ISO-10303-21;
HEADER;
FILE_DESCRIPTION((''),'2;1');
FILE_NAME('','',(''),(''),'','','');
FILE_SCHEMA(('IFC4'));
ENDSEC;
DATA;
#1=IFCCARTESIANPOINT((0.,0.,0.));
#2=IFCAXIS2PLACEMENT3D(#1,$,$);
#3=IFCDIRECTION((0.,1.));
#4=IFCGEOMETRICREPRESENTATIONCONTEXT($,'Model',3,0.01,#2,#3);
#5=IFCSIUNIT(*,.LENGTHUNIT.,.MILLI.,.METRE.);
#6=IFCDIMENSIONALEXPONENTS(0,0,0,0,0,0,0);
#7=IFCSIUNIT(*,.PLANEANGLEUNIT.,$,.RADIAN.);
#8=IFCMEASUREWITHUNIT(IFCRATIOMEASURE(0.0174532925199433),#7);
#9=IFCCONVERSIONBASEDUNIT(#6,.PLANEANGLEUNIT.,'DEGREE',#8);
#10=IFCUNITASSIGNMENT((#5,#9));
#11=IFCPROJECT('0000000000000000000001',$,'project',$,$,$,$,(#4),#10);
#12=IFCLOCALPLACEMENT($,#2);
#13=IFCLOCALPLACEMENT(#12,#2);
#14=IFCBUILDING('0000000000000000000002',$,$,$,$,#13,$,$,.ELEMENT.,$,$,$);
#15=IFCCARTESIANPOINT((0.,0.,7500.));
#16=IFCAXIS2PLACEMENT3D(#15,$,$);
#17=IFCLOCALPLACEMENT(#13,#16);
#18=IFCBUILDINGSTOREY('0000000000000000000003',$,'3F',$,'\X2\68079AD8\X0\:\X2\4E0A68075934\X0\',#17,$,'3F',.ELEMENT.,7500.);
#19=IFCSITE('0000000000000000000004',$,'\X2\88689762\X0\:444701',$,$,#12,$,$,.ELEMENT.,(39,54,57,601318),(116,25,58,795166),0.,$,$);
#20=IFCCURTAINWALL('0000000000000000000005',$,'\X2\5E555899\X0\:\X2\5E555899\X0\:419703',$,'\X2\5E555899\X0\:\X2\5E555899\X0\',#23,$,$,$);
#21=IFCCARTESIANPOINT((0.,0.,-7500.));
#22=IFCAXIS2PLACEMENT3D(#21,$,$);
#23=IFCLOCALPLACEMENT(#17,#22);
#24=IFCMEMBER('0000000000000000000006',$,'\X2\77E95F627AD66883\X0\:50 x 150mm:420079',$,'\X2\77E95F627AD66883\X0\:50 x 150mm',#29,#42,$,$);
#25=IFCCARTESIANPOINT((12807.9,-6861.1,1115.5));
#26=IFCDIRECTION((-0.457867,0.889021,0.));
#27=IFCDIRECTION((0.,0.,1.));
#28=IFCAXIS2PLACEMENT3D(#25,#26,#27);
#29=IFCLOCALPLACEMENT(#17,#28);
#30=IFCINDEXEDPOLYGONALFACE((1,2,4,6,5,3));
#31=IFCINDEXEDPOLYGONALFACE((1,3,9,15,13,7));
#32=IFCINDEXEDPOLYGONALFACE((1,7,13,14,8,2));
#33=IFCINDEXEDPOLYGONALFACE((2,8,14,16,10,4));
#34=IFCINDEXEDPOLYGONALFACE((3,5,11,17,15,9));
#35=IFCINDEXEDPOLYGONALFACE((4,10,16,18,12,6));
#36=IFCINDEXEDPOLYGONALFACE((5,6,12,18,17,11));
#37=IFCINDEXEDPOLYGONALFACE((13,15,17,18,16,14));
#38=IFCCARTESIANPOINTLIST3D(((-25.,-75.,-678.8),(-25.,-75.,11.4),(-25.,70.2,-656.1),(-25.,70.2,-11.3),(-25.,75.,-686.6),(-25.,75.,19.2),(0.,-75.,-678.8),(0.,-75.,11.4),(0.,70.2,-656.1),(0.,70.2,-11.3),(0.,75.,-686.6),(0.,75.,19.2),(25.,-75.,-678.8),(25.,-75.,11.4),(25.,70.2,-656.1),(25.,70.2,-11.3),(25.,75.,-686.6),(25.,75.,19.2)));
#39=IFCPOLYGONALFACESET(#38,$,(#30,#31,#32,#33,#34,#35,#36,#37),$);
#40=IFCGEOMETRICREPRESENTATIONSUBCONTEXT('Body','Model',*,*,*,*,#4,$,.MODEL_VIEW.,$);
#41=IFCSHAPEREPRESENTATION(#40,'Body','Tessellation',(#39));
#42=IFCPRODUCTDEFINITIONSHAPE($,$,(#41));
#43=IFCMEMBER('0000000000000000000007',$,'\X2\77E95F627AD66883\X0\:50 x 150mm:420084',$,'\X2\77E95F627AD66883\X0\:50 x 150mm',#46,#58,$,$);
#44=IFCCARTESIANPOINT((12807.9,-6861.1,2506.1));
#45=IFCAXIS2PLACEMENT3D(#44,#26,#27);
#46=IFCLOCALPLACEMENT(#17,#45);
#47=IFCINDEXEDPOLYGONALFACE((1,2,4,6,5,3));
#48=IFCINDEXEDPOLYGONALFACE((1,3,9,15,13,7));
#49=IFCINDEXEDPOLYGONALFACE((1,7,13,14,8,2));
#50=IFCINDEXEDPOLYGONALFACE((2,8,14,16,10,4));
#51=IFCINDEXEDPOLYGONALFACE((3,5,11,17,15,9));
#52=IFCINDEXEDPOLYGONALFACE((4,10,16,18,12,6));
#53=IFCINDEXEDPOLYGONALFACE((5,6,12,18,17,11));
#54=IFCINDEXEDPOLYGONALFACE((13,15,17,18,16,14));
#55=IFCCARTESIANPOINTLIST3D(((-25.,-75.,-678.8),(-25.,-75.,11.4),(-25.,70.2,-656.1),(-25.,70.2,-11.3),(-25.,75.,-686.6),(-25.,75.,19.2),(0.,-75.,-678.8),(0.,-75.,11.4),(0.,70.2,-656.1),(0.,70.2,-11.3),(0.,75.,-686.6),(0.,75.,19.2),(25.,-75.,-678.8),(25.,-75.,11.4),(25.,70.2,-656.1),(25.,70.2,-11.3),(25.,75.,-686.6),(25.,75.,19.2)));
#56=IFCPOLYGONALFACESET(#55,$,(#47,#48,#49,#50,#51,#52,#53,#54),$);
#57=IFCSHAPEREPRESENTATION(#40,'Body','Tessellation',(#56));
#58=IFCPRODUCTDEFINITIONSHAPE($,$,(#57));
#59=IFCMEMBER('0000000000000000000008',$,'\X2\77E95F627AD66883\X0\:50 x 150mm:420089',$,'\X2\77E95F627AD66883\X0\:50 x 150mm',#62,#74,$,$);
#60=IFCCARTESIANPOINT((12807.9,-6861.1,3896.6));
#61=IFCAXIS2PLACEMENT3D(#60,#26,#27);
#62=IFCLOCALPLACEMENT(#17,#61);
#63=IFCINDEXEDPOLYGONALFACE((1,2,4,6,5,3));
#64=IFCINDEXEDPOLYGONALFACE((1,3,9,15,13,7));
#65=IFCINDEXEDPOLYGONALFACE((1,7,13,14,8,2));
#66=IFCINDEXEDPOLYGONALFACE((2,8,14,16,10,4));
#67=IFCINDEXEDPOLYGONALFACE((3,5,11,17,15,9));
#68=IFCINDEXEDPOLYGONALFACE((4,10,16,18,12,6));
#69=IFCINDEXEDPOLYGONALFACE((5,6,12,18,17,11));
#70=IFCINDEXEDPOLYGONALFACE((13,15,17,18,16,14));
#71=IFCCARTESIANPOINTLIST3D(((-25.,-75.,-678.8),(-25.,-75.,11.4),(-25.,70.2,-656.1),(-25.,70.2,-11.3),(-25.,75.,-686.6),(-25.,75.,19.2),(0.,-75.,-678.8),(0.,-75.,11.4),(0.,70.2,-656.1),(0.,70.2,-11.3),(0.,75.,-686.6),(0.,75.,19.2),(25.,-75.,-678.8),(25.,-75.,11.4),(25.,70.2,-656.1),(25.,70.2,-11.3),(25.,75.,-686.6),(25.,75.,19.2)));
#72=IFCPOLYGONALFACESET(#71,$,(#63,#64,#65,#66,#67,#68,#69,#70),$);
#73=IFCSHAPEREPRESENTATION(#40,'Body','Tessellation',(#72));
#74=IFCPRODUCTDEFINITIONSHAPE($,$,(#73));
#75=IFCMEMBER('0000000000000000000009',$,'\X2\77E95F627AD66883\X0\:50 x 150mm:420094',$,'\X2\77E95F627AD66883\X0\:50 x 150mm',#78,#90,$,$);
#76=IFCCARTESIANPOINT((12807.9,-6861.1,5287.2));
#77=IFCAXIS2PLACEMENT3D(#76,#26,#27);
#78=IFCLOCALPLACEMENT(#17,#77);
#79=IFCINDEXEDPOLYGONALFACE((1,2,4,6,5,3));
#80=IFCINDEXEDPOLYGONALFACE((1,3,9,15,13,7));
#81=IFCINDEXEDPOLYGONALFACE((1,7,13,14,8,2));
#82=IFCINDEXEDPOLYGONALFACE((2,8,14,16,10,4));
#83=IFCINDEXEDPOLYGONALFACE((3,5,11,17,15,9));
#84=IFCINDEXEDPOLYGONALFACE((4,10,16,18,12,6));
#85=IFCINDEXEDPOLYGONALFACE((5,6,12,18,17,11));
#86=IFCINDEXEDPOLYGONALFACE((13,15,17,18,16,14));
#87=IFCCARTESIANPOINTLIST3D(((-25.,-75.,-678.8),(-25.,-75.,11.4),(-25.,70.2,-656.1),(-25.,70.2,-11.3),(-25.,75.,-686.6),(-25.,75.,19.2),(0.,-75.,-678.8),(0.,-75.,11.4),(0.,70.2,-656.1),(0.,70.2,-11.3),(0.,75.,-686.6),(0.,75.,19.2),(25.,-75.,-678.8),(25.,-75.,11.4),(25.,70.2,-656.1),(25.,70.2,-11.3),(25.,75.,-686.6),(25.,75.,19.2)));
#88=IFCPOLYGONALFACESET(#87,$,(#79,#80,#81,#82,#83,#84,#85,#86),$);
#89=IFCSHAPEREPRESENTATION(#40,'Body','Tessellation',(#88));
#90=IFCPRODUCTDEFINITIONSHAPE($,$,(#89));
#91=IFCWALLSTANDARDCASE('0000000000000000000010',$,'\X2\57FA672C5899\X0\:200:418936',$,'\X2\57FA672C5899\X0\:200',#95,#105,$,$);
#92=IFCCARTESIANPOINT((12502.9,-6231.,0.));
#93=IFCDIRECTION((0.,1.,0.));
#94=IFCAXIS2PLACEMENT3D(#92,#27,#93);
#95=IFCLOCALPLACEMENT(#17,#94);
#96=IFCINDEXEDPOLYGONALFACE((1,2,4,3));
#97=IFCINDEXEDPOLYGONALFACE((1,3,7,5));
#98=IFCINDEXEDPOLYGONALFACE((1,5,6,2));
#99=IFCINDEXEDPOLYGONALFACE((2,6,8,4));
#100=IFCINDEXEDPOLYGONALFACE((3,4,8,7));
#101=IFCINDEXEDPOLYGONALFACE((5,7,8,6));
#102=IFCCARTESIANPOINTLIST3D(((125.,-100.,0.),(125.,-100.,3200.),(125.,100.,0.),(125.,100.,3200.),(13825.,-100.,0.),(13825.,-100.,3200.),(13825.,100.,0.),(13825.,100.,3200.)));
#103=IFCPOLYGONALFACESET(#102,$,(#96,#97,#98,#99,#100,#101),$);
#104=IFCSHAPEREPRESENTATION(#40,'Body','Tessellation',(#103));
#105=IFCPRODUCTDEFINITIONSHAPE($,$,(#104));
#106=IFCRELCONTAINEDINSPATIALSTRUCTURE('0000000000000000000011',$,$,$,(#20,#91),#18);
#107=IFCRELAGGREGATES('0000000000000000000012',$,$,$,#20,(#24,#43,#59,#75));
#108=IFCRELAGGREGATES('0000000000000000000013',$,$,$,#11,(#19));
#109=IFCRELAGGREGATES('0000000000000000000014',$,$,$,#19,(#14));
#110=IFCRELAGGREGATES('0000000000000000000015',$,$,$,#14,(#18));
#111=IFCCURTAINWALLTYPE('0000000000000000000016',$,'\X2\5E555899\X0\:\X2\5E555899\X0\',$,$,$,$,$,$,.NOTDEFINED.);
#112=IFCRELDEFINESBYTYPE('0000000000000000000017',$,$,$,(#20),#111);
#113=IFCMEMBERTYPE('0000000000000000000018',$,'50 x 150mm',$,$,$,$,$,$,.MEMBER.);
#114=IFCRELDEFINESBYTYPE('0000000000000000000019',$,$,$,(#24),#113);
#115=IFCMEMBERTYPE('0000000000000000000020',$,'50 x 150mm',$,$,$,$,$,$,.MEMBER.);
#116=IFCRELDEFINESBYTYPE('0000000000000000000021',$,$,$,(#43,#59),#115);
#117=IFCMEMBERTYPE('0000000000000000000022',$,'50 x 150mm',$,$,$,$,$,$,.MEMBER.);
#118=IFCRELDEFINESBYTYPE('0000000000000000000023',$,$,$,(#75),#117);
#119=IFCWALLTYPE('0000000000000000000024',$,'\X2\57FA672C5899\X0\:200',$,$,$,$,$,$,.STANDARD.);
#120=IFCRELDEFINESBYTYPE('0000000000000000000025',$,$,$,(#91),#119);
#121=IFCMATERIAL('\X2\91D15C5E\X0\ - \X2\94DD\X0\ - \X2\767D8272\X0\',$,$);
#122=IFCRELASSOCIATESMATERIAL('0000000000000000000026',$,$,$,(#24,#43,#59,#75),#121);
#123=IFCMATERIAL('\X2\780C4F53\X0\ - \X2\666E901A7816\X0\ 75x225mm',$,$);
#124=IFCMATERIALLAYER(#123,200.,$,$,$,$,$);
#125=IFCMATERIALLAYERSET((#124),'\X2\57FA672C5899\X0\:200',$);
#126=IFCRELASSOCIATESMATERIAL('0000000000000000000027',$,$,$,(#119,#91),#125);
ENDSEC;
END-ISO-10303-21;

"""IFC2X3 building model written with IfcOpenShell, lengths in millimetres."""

from ifc_helpers import new_model, entity, si_unit, converted_unit, direction, frame, frame_2d, origin, origin_2d_with_axis, place, context, subcontext, project, spatial, polyline, rectangle, extrude, clip, bounded_halfspace, source, transform, mapped, material, layer, layer_set, layer_usage, type_object, type_shapes, element, aggregate, save


model = new_model("IFC2X3")

# Units and contexts
model_context = context("Model", 3, precision=0.01, world=origin(), true_north=direction((0.0, 1.0)))
body_context = subcontext(model_context, "Body", "Model", "MODEL_VIEW")
ifc_project = project(units=[si_unit("LENGTHUNIT", "METRE", prefix="MILLI"), converted_unit("PLANEANGLEUNIT", "DEGREE", entity("IfcRatioMeasure", 0.0174532925199433), si_unit("PLANEANGLEUNIT", "RADIAN"), dimensions=[0, 0, 0, 0, 0, 0, 0])], contexts=[model_context])

# Site, building, storey
site_placement = place(None, origin())
site = spatial("IfcSite", under=ifc_project, at=site_placement, Name="表面:444701", CompositionType="ELEMENT", RefLatitude=(39, 54, 57, 601318), RefLongitude=(116, 25, 58, 795166), RefElevation=0.0)
building_placement = place(site_placement, origin())
building = spatial("IfcBuilding", under=site, at=building_placement, CompositionType="ELEMENT")
storey_placement = place(building_placement, frame((0.0, 0.0, 7500.0)))
storey = spatial("IfcBuildingStorey", under=building, at=storey_placement, Name="3F", ObjectType="标高:上标头", LongName="3F", CompositionType="ELEMENT", Elevation=7500.0)

# Shared definitions
curtain_wall_type = type_object("IfcCurtainWallType", Name="幕墙:幕墙", PredefinedType="NOTDEFINED")
ifc_material_1 = material(Name="金属 - 铝 - 白色")

# Curtain wall, members
curtain_wall_1_placement = place(storey_placement, frame((0.0, 0.0, -7500.0)))
curtain_wall_1 = element("IfcCurtainWall", 1, at=curtain_wall_1_placement, inside=storey, type_object=curtain_wall_type, Name="幕墙:幕墙:419703", ObjectType="幕墙:幕墙")
member_type_1 = type_object("IfcMemberType", Name="50 x 150mm", PredefinedType="MEMBER")
shared_shape_1 = source(origin(), body_context, "Body", "Clipping", [
    clip(clip(clip(clip(clip(clip(clip(clip(extrude(rectangle(XDim=150.0, YDim=50.0, at=origin_2d_with_axis()), frame((0.0, 0.0, -686.6), z_axis=(0.0, 0.0, 1.0), x_axis=(0.0, -1.0, 0.0)), (0.0, 0.0, 1.0), 705.8), bounded_halfspace(frame((-1415.5, -78.0, -679.3), z_axis=(0.0, 0.154283, -0.988027), x_axis=(1.0, 0.0, 0.0)), False, frame((0.0, 0.0, -686.6), z_axis=(0.0, 0.0, 1.0), x_axis=(0.0, -1.0, 0.0)), polyline([(75.0, 0.0), (75.0, -25.0), (-70.2, -25.0), (-70.2, 0.0), (75.0, 0.0)]))), bounded_halfspace(frame((0.0, -78.0, -679.3), z_axis=(0.0, 0.154283, -0.988027), x_axis=(1.0, 0.0, 0.0)), False, frame((0.0, 0.0, -686.6), z_axis=(0.0, 0.0, 1.0), x_axis=(0.0, -1.0, 0.0)), polyline([(-70.2, 25.0), (75.0, 25.0), (75.0, 0.0), (-70.2, 0.0), (-70.2, 25.0)]))), bounded_halfspace(frame((-1415.5, 70.2, -656.1), z_axis=(0.0, -0.988027, -0.154283), x_axis=(1.0, 0.0, 0.0)), False, frame((0.0, 0.0, -686.6), z_axis=(0.0, 0.0, 1.0), x_axis=(0.0, -1.0, 0.0)), polyline([(-70.2, -25.0), (-75.0, -25.0), (-75.0, 0.0), (-70.2, 0.0), (-70.2, -25.0)]))), bounded_halfspace(frame((0.0, 70.2, -656.1), z_axis=(0.0, -0.988027, -0.154283), x_axis=(1.0, 0.0, 0.0)), False, frame((0.0, 0.0, -686.6), z_axis=(0.0, 0.0, 1.0), x_axis=(0.0, -1.0, 0.0)), polyline([(-75.0, 25.0), (-70.2, 25.0), (-70.2, 0.0), (-75.0, 0.0), (-75.0, 25.0)]))), bounded_halfspace(frame((-1415.5, 78.0, 38.1), z_axis=(0.0, -0.988027, 0.154283), x_axis=(1.0, 0.0, 0.0)), False, frame((0.0, 0.0, -686.6), z_axis=(0.0, 0.0, 1.0), x_axis=(0.0, -1.0, 0.0)), polyline([(-75.0, 0.0), (-75.0, -25.0), (-70.2, -25.0), (-70.2, 0.0), (-75.0, 0.0)]))), bounded_halfspace(frame((0.0, 78.0, 38.1), z_axis=(0.0, -0.988027, 0.154283), x_axis=(1.0, 0.0, 0.0)), False, frame((0.0, 0.0, -686.6), z_axis=(0.0, 0.0, 1.0), x_axis=(0.0, -1.0, 0.0)), polyline([(-75.0, 25.0), (-75.0, 0.0), (-70.2, 0.0), (-70.2, 25.0), (-75.0, 25.0)]))), bounded_halfspace(frame((-1415.5, 70.2, -11.3), z_axis=(0.0, 0.154283, 0.988027), x_axis=(1.0, 0.0, 0.0)), False, frame((0.0, 0.0, -686.6), z_axis=(0.0, 0.0, 1.0), x_axis=(0.0, -1.0, 0.0)), polyline([(-70.2, -25.0), (75.0, -25.0), (75.0, 0.0), (-70.2, 0.0), (-70.2, -25.0)]))), bounded_halfspace(frame((0.0, 70.2, -11.3), z_axis=(0.0, 0.154283, 0.988027), x_axis=(1.0, 0.0, 0.0)), False, frame((0.0, 0.0, -686.6), z_axis=(0.0, 0.0, 1.0), x_axis=(0.0, -1.0, 0.0)), polyline([(75.0, 0.0), (75.0, 25.0), (-70.2, 25.0), (-70.2, 0.0), (75.0, 0.0)]))),
])
type_shapes(member_type_1, [shared_shape_1])
member_1_placement = place(storey_placement, frame((12807.9, -6861.1, 1115.5), z_axis=(-0.457867, 0.889021, 0.0), x_axis=(0.0, 0.0, 1.0)))
member_1 = element("IfcMember", 2, at=member_1_placement, type_object=member_type_1, material=ifc_material_1, Name="矩形竖梃:50 x 150mm:420079", ObjectType="矩形竖梃:50 x 150mm", context=body_context, shape_type="MappedRepresentation", body=[
    mapped(shared_shape_1, transform((0.0, 0.0, 0.0), scale=1.0)),
])
member_type_2 = type_object("IfcMemberType", Name="50 x 150mm", PredefinedType="MEMBER")
shared_shape_2 = source(origin(), body_context, "Body", "Clipping", [
    clip(clip(clip(clip(clip(clip(clip(clip(extrude(rectangle(XDim=150.0, YDim=50.0, at=origin_2d_with_axis()), frame((0.0, 0.0, -686.6), z_axis=(0.0, 0.0, 1.0), x_axis=(0.0, -1.0, 0.0)), (0.0, 0.0, 1.0), 705.8), bounded_halfspace(frame((-1390.5, -78.0, -679.3), z_axis=(0.0, 0.154283, -0.988027), x_axis=(1.0, 0.0, 0.0)), False, frame((0.0, 0.0, -686.6), z_axis=(0.0, 0.0, 1.0), x_axis=(0.0, -1.0, 0.0)), polyline([(75.0, 0.0), (75.0, -25.0), (-70.2, -25.0), (-70.2, 0.0), (75.0, 0.0)]))), bounded_halfspace(frame((0.0, -78.0, -679.3), z_axis=(0.0, 0.154283, -0.988027), x_axis=(1.0, 0.0, 0.0)), False, frame((0.0, 0.0, -686.6), z_axis=(0.0, 0.0, 1.0), x_axis=(0.0, -1.0, 0.0)), polyline([(-70.2, 25.0), (75.0, 25.0), (75.0, 0.0), (-70.2, 0.0), (-70.2, 25.0)]))), bounded_halfspace(frame((-1390.5, 70.2, -656.1), z_axis=(0.0, -0.988027, -0.154283), x_axis=(1.0, 0.0, 0.0)), False, frame((0.0, 0.0, -686.6), z_axis=(0.0, 0.0, 1.0), x_axis=(0.0, -1.0, 0.0)), polyline([(-70.2, -25.0), (-75.0, -25.0), (-75.0, 0.0), (-70.2, 0.0), (-70.2, -25.0)]))), bounded_halfspace(frame((0.0, 70.2, -656.1), z_axis=(0.0, -0.988027, -0.154283), x_axis=(1.0, 0.0, 0.0)), False, frame((0.0, 0.0, -686.6), z_axis=(0.0, 0.0, 1.0), x_axis=(0.0, -1.0, 0.0)), polyline([(-75.0, 25.0), (-70.2, 25.0), (-70.2, 0.0), (-75.0, 0.0), (-75.0, 25.0)]))), bounded_halfspace(frame((-1390.5, 78.0, 38.1), z_axis=(0.0, -0.988027, 0.154283), x_axis=(1.0, 0.0, 0.0)), False, frame((0.0, 0.0, -686.6), z_axis=(0.0, 0.0, 1.0), x_axis=(0.0, -1.0, 0.0)), polyline([(-75.0, 0.0), (-75.0, -25.0), (-70.2, -25.0), (-70.2, 0.0), (-75.0, 0.0)]))), bounded_halfspace(frame((0.0, 78.0, 38.1), z_axis=(0.0, -0.988027, 0.154283), x_axis=(1.0, 0.0, 0.0)), False, frame((0.0, 0.0, -686.6), z_axis=(0.0, 0.0, 1.0), x_axis=(0.0, -1.0, 0.0)), polyline([(-75.0, 25.0), (-75.0, 0.0), (-70.2, 0.0), (-70.2, 25.0), (-75.0, 25.0)]))), bounded_halfspace(frame((-1390.5, 70.2, -11.3), z_axis=(0.0, 0.154283, 0.988027), x_axis=(1.0, 0.0, 0.0)), False, frame((0.0, 0.0, -686.6), z_axis=(0.0, 0.0, 1.0), x_axis=(0.0, -1.0, 0.0)), polyline([(-70.2, -25.0), (75.0, -25.0), (75.0, 0.0), (-70.2, 0.0), (-70.2, -25.0)]))), bounded_halfspace(frame((0.0, 70.2, -11.3), z_axis=(0.0, 0.154283, 0.988027), x_axis=(1.0, 0.0, 0.0)), False, frame((0.0, 0.0, -686.6), z_axis=(0.0, 0.0, 1.0), x_axis=(0.0, -1.0, 0.0)), polyline([(75.0, 0.0), (75.0, 25.0), (-70.2, 25.0), (-70.2, 0.0), (75.0, 0.0)]))),
])
type_shapes(member_type_2, [shared_shape_2])
member_2_placement = place(storey_placement, frame((12807.9, -6861.1, 2506.1), z_axis=(-0.457867, 0.889021, 0.0), x_axis=(0.0, 0.0, 1.0)))
member_2 = element("IfcMember", 3, at=member_2_placement, type_object=member_type_2, material=ifc_material_1, Name="矩形竖梃:50 x 150mm:420084", ObjectType="矩形竖梃:50 x 150mm", context=body_context, shape_type="MappedRepresentation", body=[
    mapped(shared_shape_2, transform((0.0, 0.0, 0.0), scale=1.0)),
])
member_3_placement = place(storey_placement, frame((12807.9, -6861.1, 3896.6), z_axis=(-0.457867, 0.889021, 0.0), x_axis=(0.0, 0.0, 1.0)))
member_3 = element("IfcMember", 4, at=member_3_placement, type_object=member_type_2, material=ifc_material_1, Name="矩形竖梃:50 x 150mm:420089", ObjectType="矩形竖梃:50 x 150mm", context=body_context, shape_type="MappedRepresentation", body=[
    mapped(shared_shape_2, transform((0.0, 0.0, 0.0), scale=1.0)),
])
member_type_3 = type_object("IfcMemberType", Name="50 x 150mm", PredefinedType="MEMBER")
shared_shape_3 = source(origin(), body_context, "Body", "Clipping", [
    clip(clip(clip(clip(clip(clip(clip(clip(extrude(rectangle(XDim=150.0, YDim=50.0, at=origin_2d_with_axis()), frame((0.0, 0.0, -686.6), z_axis=(0.0, 0.0, 1.0), x_axis=(0.0, -1.0, 0.0)), (0.0, 0.0, 1.0), 705.8), bounded_halfspace(frame((-1390.5, -78.0, -679.3), z_axis=(0.0, 0.154283, -0.988027), x_axis=(1.0, 0.0, 0.0)), False, frame((0.0, 0.0, -686.6), z_axis=(0.0, 0.0, 1.0), x_axis=(0.0, -1.0, 0.0)), polyline([(75.0, 0.0), (75.0, -25.0), (-70.2, -25.0), (-70.2, 0.0), (75.0, 0.0)]))), bounded_halfspace(frame((0.0, -78.0, -679.3), z_axis=(0.0, 0.154283, -0.988027), x_axis=(1.0, 0.0, 0.0)), False, frame((0.0, 0.0, -686.6), z_axis=(0.0, 0.0, 1.0), x_axis=(0.0, -1.0, 0.0)), polyline([(-70.2, 25.0), (75.0, 25.0), (75.0, 0.0), (-70.2, 0.0), (-70.2, 25.0)]))), bounded_halfspace(frame((-1390.5, 70.2, -656.1), z_axis=(0.0, -0.988027, -0.154283), x_axis=(1.0, 0.0, 0.0)), False, frame((0.0, 0.0, -686.6), z_axis=(0.0, 0.0, 1.0), x_axis=(0.0, -1.0, 0.0)), polyline([(-70.2, -25.0), (-75.0, -25.0), (-75.0, 0.0), (-70.2, 0.0), (-70.2, -25.0)]))), bounded_halfspace(frame((0.0, 70.2, -656.1), z_axis=(0.0, -0.988027, -0.154283), x_axis=(1.0, 0.0, 0.0)), False, frame((0.0, 0.0, -686.6), z_axis=(0.0, 0.0, 1.0), x_axis=(0.0, -1.0, 0.0)), polyline([(-75.0, 25.0), (-70.2, 25.0), (-70.2, 0.0), (-75.0, 0.0), (-75.0, 25.0)]))), bounded_halfspace(frame((-1390.5, 78.0, 38.1), z_axis=(0.0, -0.988027, 0.154283), x_axis=(1.0, 0.0, 0.0)), False, frame((0.0, 0.0, -686.6), z_axis=(0.0, 0.0, 1.0), x_axis=(0.0, -1.0, 0.0)), polyline([(-75.0, 0.0), (-75.0, -25.0), (-70.2, -25.0), (-70.2, 0.0), (-75.0, 0.0)]))), bounded_halfspace(frame((0.0, 78.0, 38.1), z_axis=(0.0, -0.988027, 0.154283), x_axis=(1.0, 0.0, 0.0)), False, frame((0.0, 0.0, -686.6), z_axis=(0.0, 0.0, 1.0), x_axis=(0.0, -1.0, 0.0)), polyline([(-75.0, 25.0), (-75.0, 0.0), (-70.2, 0.0), (-70.2, 25.0), (-75.0, 25.0)]))), bounded_halfspace(frame((-1390.5, 70.2, -11.3), z_axis=(0.0, 0.154283, 0.988027), x_axis=(1.0, 0.0, 0.0)), False, frame((0.0, 0.0, -686.6), z_axis=(0.0, 0.0, 1.0), x_axis=(0.0, -1.0, 0.0)), polyline([(-70.2, -25.0), (75.0, -25.0), (75.0, 0.0), (-70.2, 0.0), (-70.2, -25.0)]))), bounded_halfspace(frame((0.0, 70.2, -11.3), z_axis=(0.0, 0.154283, 0.988027), x_axis=(1.0, 0.0, 0.0)), False, frame((0.0, 0.0, -686.6), z_axis=(0.0, 0.0, 1.0), x_axis=(0.0, -1.0, 0.0)), polyline([(75.0, 0.0), (75.0, 25.0), (-70.2, 25.0), (-70.2, 0.0), (75.0, 0.0)]))),
])
type_shapes(member_type_3, [shared_shape_3])
member_4_placement = place(storey_placement, frame((12807.9, -6861.1, 5287.2), z_axis=(-0.457867, 0.889021, 0.0), x_axis=(0.0, 0.0, 1.0)))
member_4 = element("IfcMember", 5, at=member_4_placement, type_object=member_type_3, material=ifc_material_1, Name="矩形竖梃:50 x 150mm:420094", ObjectType="矩形竖梃:50 x 150mm", context=body_context, shape_type="MappedRepresentation", body=[
    mapped(shared_shape_3, transform((0.0, 0.0, 0.0), scale=1.0)),
])
aggregate(curtain_wall_1, [member_1, member_2, member_3, member_4])

# Shared definitions
ifc_material_2 = material(Name="砌体 - 普通砖 75x225mm")

# Wall
ifc_layer_1 = layer(ifc_material_2, 200.0)
ifc_layer_set_1 = layer_set([ifc_layer_1], Name="基本墙:200")
wall_type_1 = type_object("IfcWallType", Name="基本墙:200", PredefinedType="STANDARD", material=ifc_layer_set_1)
ifc_layer_usage_1 = layer_usage(ifc_layer_set_1, "AXIS2", "NEGATIVE", 100.0)
wall_1_placement = place(storey_placement, frame((12502.9, -6231.0, 0.0), z_axis=(0.0, 0.0, 1.0), x_axis=(0.0, 1.0, 0.0)))
element("IfcWallStandardCase", 6, at=wall_1_placement, inside=storey, type_object=wall_type_1, material=ifc_layer_usage_1, Name="基本墙:200:418936", ObjectType="基本墙:200", context=body_context, shape_type="SweptSolid", body=[
    extrude(rectangle(XDim=13700.0, YDim=200.0, at=frame_2d((6975.0, 0.0), x_axis=(-1.0, 0.0))), origin(), (0.0, 0.0, 1.0), 3200.0),
])

save(model, "model.ifc")
